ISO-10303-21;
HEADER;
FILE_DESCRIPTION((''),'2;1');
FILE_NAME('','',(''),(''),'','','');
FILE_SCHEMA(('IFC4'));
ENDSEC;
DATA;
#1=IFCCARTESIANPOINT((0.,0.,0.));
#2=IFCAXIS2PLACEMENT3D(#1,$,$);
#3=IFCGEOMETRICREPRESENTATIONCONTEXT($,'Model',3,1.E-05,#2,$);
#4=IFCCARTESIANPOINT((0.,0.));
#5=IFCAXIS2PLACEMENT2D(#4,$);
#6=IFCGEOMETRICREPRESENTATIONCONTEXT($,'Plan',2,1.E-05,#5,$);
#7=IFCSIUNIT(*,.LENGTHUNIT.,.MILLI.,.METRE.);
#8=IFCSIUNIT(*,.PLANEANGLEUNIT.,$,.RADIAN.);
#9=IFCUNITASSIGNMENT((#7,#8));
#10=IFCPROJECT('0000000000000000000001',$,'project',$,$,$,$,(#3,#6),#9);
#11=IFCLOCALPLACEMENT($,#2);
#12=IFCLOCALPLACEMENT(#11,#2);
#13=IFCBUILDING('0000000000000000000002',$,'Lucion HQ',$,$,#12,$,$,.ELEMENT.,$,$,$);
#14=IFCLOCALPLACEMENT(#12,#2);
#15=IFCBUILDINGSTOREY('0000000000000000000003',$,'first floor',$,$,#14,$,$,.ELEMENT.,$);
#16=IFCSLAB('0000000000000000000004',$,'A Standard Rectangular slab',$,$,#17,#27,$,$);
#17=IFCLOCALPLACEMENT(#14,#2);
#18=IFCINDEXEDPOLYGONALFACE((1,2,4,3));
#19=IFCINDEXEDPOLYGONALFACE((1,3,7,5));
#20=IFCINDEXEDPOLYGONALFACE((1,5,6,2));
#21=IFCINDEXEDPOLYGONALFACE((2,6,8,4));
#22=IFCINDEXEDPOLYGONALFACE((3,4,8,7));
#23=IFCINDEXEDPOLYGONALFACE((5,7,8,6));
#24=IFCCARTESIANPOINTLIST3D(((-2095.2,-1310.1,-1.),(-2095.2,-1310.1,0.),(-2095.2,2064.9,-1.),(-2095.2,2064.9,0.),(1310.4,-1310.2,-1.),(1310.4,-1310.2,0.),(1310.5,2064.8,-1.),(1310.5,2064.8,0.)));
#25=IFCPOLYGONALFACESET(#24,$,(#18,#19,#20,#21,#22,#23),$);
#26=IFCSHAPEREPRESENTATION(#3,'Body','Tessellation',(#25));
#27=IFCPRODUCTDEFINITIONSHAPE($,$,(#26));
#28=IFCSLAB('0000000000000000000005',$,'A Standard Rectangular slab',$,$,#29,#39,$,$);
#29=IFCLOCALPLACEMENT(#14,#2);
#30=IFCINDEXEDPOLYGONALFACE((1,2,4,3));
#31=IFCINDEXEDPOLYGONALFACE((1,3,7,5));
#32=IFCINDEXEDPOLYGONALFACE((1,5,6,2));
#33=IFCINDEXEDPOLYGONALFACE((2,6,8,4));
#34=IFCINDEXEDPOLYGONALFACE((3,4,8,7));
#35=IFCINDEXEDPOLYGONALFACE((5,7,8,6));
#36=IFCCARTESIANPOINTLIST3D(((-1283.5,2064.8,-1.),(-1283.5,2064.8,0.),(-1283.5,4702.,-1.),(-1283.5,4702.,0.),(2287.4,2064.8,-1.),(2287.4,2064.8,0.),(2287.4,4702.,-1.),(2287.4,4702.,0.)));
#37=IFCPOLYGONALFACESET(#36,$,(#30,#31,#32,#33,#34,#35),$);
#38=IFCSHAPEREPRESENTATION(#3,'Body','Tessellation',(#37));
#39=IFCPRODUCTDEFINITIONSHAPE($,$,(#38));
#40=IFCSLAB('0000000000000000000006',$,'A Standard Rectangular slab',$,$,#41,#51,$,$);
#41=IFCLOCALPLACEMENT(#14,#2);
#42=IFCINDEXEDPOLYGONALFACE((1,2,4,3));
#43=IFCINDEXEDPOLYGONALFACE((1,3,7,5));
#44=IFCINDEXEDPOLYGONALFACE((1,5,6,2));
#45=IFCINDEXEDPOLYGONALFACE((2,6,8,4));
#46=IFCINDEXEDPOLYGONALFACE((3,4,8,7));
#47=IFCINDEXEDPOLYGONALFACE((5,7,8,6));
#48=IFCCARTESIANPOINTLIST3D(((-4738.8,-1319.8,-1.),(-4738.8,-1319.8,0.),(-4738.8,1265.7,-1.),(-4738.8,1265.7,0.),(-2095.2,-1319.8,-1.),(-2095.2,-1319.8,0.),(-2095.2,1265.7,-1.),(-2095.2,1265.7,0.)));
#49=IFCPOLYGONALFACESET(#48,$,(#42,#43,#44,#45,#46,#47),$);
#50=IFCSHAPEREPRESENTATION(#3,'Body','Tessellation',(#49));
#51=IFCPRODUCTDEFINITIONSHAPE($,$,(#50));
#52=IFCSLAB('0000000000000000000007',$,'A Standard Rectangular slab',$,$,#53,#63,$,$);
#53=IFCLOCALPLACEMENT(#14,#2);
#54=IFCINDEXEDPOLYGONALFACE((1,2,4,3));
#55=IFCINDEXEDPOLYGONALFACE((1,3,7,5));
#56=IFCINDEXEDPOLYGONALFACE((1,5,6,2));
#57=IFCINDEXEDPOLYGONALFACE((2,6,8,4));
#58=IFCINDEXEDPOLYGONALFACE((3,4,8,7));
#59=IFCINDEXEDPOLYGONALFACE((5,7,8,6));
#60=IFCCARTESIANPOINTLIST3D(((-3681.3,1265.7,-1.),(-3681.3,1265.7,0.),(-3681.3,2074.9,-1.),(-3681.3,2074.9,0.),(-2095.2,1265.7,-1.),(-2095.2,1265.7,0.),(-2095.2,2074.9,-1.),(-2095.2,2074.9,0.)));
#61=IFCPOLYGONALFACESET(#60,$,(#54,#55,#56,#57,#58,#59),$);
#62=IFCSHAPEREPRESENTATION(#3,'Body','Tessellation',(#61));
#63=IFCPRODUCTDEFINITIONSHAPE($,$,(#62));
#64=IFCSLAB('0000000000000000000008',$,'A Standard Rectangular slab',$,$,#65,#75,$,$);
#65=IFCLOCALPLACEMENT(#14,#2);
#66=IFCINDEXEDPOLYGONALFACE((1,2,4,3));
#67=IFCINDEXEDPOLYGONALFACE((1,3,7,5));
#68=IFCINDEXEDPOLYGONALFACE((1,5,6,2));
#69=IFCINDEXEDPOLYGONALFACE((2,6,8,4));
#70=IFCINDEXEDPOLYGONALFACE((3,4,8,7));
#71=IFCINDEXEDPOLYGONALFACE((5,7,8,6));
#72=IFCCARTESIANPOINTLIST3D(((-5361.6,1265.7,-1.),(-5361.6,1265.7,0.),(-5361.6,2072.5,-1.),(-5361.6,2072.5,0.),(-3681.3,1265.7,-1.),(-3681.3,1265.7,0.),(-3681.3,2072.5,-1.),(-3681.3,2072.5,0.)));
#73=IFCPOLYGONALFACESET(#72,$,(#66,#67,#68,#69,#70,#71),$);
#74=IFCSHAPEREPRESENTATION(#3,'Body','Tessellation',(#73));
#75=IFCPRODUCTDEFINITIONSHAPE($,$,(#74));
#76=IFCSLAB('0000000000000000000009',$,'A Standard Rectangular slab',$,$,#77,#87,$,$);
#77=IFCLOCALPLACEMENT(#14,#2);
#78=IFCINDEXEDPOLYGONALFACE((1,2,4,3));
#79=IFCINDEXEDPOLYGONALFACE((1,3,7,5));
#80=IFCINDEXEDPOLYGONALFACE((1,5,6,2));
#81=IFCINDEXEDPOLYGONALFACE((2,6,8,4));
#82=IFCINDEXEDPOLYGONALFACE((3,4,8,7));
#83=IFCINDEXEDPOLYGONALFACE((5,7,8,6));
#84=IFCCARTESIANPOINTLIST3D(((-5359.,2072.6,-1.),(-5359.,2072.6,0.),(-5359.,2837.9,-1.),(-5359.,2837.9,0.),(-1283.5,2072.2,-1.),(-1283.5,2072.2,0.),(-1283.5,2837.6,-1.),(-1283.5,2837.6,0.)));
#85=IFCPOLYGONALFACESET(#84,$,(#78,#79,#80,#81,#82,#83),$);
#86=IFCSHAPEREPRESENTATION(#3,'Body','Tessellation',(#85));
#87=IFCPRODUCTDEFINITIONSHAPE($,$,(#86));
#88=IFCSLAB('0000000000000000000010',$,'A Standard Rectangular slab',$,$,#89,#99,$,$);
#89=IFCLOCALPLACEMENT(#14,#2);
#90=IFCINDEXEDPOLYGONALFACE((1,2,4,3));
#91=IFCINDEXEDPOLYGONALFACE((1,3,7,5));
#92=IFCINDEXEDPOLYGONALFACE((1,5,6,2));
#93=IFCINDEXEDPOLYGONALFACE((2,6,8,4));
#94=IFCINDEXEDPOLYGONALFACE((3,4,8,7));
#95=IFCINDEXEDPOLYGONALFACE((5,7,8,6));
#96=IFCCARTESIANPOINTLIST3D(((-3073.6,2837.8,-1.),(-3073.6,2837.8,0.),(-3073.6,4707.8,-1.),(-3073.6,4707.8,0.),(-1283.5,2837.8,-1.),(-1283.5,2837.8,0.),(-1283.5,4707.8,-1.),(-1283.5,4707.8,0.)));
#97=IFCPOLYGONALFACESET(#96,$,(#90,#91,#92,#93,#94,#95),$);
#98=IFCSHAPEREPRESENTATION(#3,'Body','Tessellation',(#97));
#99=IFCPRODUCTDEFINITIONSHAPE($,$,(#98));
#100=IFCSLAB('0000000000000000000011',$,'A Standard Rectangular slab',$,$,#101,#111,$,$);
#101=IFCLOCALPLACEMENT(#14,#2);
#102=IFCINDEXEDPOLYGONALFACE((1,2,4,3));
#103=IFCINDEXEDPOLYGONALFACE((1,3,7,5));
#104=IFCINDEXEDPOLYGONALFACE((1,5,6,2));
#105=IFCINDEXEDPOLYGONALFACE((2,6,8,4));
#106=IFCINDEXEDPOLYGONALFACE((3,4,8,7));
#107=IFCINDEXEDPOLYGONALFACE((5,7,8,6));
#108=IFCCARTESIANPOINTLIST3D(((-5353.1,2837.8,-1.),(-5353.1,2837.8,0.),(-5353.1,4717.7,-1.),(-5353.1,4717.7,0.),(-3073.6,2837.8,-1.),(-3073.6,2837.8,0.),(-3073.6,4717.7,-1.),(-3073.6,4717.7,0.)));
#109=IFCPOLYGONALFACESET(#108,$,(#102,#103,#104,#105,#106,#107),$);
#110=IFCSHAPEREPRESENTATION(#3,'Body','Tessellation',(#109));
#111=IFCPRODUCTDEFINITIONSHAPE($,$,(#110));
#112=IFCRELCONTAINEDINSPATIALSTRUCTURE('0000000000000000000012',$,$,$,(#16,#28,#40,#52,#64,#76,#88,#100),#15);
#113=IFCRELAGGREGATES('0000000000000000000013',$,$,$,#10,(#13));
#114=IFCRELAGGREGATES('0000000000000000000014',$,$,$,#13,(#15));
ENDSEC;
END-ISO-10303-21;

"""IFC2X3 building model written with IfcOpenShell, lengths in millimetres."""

from ifc_helpers import new_model, si_unit, frame, origin, origin_2d, place, context, project, spatial, polyline, outline, extrude, element, save


model = new_model("IFC2X3")

# Units and contexts
model_context = context("Model", 3, precision=1e-05, world=origin())
plan_context = context("Plan", 2, precision=1e-05, world=origin_2d())
ifc_project = project(units=[si_unit("LENGTHUNIT", "METRE", prefix="MILLI"), si_unit("PLANEANGLEUNIT", "RADIAN")], contexts=[model_context, plan_context])

# Building, storey
placement_1 = place(None, origin())
building_placement = place(placement_1, origin())
building = spatial("IfcBuilding", under=ifc_project, at=building_placement, Name="Lucion HQ", CompositionType="ELEMENT")
storey_placement = place(building_placement, origin())
storey = spatial("IfcBuildingStorey", under=building, at=storey_placement, Name="first floor", CompositionType="ELEMENT")

# Slabs
placement_2 = place(None, frame((-392.3, 377.4, 0.0)))
slab_1_placement = place(placement_2, origin())
element("IfcSlab", 1, at=slab_1_placement, inside=storey, Name="A Standard Rectangular slab", context=model_context, shape_type="SweptSolid", body=[
    extrude(outline(polyline([(1702.8, -1687.5, 0.0), (-1702.9, -1687.5, 0.0), (-1702.8, 1687.5, 0.0), (1702.9, 1687.4, 0.0), (1702.8, -1687.5, 0.0)]), kind="CURVE"), origin(), (0.0, 0.0, -1.0), 1.0),
])
placement_3 = place(None, frame((501.9, 3383.4, 0.0)))
slab_2_placement = place(placement_3, origin())
element("IfcSlab", 2, at=slab_2_placement, inside=storey, Name="A Standard Rectangular slab", context=model_context, shape_type="SweptSolid", body=[
    extrude(outline(polyline([(1785.4, -1318.6, 0.0), (-1785.4, -1318.6, 0.0), (-1785.4, 1318.6, 0.0), (1785.4, 1318.6, 0.0), (1785.4, -1318.6, 0.0)]), kind="CURVE"), origin(), (0.0, 0.0, -1.0), 1.0),
])
placement_4 = place(None, frame((-3417.0, -27.1, 0.0)))
slab_3_placement = place(placement_4, origin())
element("IfcSlab", 3, at=slab_3_placement, inside=storey, Name="A Standard Rectangular slab", context=model_context, shape_type="SweptSolid", body=[
    extrude(outline(polyline([(1321.8, -1292.8, 0.0), (-1321.8, -1292.8, 0.0), (-1321.8, 1292.8, 0.0), (1321.8, 1292.8, 0.0), (1321.8, -1292.8, 0.0)]), kind="CURVE"), origin(), (0.0, 0.0, -1.0), 1.0),
])
placement_5 = place(None, frame((-2888.2, 1670.3, 0.0)))
slab_4_placement = place(placement_5, origin())
element("IfcSlab", 4, at=slab_4_placement, inside=storey, Name="A Standard Rectangular slab", context=model_context, shape_type="SweptSolid", body=[
    extrude(outline(polyline([(793.1, -404.6, 0.0), (-793.1, -404.6, 0.0), (-793.1, 404.6, 0.0), (793.1, 404.6, 0.0), (793.1, -404.6, 0.0)]), kind="CURVE"), origin(), (0.0, 0.0, -1.0), 1.0),
])
placement_6 = place(None, frame((-4521.5, 1669.1, 0.0)))
slab_5_placement = place(placement_6, origin())
element("IfcSlab", 5, at=slab_5_placement, inside=storey, Name="A Standard Rectangular slab", context=model_context, shape_type="SweptSolid", body=[
    extrude(outline(polyline([(840.1, -403.4, 0.0), (-840.1, -403.4, 0.0), (-840.1, 403.4, 0.0), (840.1, 403.4, 0.0), (840.1, -403.4, 0.0)]), kind="CURVE"), origin(), (0.0, 0.0, -1.0), 1.0),
])
placement_7 = place(None, frame((-3321.3, 2455.0, 0.0)))
slab_6_placement = place(placement_7, origin())
element("IfcSlab", 6, at=slab_6_placement, inside=storey, Name="A Standard Rectangular slab", context=model_context, shape_type="SweptSolid", body=[
    extrude(outline(polyline([(2037.7, -382.8, 0.0), (-2037.8, -382.4, 0.0), (-2037.7, 382.8, 0.0), (2037.8, 382.6, 0.0), (2037.7, -382.8, 0.0)]), kind="CURVE"), origin(), (0.0, 0.0, -1.0), 1.0),
])
placement_8 = place(None, frame((-2178.6, 3772.8, 0.0)))
slab_7_placement = place(placement_8, origin())
element("IfcSlab", 7, at=slab_7_placement, inside=storey, Name="A Standard Rectangular slab", context=model_context, shape_type="SweptSolid", body=[
    extrude(outline(polyline([(895.1, -935.0, 0.0), (-895.1, -935.0, 0.0), (-895.1, 935.0, 0.0), (895.1, 935.0, 0.0), (895.1, -935.0, 0.0)]), kind="CURVE"), origin(), (0.0, 0.0, -1.0), 1.0),
])
placement_9 = place(None, frame((-4213.4, 3777.8, 0.0)))
slab_8_placement = place(placement_9, origin())
element("IfcSlab", 8, at=slab_8_placement, inside=storey, Name="A Standard Rectangular slab", context=model_context, shape_type="SweptSolid", body=[
    extrude(outline(polyline([(1139.8, -939.9, 0.0), (-1139.8, -939.9, 0.0), (-1139.8, 939.9, 0.0), (1139.8, 939.9, 0.0), (1139.8, -939.9, 0.0)]), kind="CURVE"), origin(), (0.0, 0.0, -1.0), 1.0),
])

save(model, "model.ifc")
